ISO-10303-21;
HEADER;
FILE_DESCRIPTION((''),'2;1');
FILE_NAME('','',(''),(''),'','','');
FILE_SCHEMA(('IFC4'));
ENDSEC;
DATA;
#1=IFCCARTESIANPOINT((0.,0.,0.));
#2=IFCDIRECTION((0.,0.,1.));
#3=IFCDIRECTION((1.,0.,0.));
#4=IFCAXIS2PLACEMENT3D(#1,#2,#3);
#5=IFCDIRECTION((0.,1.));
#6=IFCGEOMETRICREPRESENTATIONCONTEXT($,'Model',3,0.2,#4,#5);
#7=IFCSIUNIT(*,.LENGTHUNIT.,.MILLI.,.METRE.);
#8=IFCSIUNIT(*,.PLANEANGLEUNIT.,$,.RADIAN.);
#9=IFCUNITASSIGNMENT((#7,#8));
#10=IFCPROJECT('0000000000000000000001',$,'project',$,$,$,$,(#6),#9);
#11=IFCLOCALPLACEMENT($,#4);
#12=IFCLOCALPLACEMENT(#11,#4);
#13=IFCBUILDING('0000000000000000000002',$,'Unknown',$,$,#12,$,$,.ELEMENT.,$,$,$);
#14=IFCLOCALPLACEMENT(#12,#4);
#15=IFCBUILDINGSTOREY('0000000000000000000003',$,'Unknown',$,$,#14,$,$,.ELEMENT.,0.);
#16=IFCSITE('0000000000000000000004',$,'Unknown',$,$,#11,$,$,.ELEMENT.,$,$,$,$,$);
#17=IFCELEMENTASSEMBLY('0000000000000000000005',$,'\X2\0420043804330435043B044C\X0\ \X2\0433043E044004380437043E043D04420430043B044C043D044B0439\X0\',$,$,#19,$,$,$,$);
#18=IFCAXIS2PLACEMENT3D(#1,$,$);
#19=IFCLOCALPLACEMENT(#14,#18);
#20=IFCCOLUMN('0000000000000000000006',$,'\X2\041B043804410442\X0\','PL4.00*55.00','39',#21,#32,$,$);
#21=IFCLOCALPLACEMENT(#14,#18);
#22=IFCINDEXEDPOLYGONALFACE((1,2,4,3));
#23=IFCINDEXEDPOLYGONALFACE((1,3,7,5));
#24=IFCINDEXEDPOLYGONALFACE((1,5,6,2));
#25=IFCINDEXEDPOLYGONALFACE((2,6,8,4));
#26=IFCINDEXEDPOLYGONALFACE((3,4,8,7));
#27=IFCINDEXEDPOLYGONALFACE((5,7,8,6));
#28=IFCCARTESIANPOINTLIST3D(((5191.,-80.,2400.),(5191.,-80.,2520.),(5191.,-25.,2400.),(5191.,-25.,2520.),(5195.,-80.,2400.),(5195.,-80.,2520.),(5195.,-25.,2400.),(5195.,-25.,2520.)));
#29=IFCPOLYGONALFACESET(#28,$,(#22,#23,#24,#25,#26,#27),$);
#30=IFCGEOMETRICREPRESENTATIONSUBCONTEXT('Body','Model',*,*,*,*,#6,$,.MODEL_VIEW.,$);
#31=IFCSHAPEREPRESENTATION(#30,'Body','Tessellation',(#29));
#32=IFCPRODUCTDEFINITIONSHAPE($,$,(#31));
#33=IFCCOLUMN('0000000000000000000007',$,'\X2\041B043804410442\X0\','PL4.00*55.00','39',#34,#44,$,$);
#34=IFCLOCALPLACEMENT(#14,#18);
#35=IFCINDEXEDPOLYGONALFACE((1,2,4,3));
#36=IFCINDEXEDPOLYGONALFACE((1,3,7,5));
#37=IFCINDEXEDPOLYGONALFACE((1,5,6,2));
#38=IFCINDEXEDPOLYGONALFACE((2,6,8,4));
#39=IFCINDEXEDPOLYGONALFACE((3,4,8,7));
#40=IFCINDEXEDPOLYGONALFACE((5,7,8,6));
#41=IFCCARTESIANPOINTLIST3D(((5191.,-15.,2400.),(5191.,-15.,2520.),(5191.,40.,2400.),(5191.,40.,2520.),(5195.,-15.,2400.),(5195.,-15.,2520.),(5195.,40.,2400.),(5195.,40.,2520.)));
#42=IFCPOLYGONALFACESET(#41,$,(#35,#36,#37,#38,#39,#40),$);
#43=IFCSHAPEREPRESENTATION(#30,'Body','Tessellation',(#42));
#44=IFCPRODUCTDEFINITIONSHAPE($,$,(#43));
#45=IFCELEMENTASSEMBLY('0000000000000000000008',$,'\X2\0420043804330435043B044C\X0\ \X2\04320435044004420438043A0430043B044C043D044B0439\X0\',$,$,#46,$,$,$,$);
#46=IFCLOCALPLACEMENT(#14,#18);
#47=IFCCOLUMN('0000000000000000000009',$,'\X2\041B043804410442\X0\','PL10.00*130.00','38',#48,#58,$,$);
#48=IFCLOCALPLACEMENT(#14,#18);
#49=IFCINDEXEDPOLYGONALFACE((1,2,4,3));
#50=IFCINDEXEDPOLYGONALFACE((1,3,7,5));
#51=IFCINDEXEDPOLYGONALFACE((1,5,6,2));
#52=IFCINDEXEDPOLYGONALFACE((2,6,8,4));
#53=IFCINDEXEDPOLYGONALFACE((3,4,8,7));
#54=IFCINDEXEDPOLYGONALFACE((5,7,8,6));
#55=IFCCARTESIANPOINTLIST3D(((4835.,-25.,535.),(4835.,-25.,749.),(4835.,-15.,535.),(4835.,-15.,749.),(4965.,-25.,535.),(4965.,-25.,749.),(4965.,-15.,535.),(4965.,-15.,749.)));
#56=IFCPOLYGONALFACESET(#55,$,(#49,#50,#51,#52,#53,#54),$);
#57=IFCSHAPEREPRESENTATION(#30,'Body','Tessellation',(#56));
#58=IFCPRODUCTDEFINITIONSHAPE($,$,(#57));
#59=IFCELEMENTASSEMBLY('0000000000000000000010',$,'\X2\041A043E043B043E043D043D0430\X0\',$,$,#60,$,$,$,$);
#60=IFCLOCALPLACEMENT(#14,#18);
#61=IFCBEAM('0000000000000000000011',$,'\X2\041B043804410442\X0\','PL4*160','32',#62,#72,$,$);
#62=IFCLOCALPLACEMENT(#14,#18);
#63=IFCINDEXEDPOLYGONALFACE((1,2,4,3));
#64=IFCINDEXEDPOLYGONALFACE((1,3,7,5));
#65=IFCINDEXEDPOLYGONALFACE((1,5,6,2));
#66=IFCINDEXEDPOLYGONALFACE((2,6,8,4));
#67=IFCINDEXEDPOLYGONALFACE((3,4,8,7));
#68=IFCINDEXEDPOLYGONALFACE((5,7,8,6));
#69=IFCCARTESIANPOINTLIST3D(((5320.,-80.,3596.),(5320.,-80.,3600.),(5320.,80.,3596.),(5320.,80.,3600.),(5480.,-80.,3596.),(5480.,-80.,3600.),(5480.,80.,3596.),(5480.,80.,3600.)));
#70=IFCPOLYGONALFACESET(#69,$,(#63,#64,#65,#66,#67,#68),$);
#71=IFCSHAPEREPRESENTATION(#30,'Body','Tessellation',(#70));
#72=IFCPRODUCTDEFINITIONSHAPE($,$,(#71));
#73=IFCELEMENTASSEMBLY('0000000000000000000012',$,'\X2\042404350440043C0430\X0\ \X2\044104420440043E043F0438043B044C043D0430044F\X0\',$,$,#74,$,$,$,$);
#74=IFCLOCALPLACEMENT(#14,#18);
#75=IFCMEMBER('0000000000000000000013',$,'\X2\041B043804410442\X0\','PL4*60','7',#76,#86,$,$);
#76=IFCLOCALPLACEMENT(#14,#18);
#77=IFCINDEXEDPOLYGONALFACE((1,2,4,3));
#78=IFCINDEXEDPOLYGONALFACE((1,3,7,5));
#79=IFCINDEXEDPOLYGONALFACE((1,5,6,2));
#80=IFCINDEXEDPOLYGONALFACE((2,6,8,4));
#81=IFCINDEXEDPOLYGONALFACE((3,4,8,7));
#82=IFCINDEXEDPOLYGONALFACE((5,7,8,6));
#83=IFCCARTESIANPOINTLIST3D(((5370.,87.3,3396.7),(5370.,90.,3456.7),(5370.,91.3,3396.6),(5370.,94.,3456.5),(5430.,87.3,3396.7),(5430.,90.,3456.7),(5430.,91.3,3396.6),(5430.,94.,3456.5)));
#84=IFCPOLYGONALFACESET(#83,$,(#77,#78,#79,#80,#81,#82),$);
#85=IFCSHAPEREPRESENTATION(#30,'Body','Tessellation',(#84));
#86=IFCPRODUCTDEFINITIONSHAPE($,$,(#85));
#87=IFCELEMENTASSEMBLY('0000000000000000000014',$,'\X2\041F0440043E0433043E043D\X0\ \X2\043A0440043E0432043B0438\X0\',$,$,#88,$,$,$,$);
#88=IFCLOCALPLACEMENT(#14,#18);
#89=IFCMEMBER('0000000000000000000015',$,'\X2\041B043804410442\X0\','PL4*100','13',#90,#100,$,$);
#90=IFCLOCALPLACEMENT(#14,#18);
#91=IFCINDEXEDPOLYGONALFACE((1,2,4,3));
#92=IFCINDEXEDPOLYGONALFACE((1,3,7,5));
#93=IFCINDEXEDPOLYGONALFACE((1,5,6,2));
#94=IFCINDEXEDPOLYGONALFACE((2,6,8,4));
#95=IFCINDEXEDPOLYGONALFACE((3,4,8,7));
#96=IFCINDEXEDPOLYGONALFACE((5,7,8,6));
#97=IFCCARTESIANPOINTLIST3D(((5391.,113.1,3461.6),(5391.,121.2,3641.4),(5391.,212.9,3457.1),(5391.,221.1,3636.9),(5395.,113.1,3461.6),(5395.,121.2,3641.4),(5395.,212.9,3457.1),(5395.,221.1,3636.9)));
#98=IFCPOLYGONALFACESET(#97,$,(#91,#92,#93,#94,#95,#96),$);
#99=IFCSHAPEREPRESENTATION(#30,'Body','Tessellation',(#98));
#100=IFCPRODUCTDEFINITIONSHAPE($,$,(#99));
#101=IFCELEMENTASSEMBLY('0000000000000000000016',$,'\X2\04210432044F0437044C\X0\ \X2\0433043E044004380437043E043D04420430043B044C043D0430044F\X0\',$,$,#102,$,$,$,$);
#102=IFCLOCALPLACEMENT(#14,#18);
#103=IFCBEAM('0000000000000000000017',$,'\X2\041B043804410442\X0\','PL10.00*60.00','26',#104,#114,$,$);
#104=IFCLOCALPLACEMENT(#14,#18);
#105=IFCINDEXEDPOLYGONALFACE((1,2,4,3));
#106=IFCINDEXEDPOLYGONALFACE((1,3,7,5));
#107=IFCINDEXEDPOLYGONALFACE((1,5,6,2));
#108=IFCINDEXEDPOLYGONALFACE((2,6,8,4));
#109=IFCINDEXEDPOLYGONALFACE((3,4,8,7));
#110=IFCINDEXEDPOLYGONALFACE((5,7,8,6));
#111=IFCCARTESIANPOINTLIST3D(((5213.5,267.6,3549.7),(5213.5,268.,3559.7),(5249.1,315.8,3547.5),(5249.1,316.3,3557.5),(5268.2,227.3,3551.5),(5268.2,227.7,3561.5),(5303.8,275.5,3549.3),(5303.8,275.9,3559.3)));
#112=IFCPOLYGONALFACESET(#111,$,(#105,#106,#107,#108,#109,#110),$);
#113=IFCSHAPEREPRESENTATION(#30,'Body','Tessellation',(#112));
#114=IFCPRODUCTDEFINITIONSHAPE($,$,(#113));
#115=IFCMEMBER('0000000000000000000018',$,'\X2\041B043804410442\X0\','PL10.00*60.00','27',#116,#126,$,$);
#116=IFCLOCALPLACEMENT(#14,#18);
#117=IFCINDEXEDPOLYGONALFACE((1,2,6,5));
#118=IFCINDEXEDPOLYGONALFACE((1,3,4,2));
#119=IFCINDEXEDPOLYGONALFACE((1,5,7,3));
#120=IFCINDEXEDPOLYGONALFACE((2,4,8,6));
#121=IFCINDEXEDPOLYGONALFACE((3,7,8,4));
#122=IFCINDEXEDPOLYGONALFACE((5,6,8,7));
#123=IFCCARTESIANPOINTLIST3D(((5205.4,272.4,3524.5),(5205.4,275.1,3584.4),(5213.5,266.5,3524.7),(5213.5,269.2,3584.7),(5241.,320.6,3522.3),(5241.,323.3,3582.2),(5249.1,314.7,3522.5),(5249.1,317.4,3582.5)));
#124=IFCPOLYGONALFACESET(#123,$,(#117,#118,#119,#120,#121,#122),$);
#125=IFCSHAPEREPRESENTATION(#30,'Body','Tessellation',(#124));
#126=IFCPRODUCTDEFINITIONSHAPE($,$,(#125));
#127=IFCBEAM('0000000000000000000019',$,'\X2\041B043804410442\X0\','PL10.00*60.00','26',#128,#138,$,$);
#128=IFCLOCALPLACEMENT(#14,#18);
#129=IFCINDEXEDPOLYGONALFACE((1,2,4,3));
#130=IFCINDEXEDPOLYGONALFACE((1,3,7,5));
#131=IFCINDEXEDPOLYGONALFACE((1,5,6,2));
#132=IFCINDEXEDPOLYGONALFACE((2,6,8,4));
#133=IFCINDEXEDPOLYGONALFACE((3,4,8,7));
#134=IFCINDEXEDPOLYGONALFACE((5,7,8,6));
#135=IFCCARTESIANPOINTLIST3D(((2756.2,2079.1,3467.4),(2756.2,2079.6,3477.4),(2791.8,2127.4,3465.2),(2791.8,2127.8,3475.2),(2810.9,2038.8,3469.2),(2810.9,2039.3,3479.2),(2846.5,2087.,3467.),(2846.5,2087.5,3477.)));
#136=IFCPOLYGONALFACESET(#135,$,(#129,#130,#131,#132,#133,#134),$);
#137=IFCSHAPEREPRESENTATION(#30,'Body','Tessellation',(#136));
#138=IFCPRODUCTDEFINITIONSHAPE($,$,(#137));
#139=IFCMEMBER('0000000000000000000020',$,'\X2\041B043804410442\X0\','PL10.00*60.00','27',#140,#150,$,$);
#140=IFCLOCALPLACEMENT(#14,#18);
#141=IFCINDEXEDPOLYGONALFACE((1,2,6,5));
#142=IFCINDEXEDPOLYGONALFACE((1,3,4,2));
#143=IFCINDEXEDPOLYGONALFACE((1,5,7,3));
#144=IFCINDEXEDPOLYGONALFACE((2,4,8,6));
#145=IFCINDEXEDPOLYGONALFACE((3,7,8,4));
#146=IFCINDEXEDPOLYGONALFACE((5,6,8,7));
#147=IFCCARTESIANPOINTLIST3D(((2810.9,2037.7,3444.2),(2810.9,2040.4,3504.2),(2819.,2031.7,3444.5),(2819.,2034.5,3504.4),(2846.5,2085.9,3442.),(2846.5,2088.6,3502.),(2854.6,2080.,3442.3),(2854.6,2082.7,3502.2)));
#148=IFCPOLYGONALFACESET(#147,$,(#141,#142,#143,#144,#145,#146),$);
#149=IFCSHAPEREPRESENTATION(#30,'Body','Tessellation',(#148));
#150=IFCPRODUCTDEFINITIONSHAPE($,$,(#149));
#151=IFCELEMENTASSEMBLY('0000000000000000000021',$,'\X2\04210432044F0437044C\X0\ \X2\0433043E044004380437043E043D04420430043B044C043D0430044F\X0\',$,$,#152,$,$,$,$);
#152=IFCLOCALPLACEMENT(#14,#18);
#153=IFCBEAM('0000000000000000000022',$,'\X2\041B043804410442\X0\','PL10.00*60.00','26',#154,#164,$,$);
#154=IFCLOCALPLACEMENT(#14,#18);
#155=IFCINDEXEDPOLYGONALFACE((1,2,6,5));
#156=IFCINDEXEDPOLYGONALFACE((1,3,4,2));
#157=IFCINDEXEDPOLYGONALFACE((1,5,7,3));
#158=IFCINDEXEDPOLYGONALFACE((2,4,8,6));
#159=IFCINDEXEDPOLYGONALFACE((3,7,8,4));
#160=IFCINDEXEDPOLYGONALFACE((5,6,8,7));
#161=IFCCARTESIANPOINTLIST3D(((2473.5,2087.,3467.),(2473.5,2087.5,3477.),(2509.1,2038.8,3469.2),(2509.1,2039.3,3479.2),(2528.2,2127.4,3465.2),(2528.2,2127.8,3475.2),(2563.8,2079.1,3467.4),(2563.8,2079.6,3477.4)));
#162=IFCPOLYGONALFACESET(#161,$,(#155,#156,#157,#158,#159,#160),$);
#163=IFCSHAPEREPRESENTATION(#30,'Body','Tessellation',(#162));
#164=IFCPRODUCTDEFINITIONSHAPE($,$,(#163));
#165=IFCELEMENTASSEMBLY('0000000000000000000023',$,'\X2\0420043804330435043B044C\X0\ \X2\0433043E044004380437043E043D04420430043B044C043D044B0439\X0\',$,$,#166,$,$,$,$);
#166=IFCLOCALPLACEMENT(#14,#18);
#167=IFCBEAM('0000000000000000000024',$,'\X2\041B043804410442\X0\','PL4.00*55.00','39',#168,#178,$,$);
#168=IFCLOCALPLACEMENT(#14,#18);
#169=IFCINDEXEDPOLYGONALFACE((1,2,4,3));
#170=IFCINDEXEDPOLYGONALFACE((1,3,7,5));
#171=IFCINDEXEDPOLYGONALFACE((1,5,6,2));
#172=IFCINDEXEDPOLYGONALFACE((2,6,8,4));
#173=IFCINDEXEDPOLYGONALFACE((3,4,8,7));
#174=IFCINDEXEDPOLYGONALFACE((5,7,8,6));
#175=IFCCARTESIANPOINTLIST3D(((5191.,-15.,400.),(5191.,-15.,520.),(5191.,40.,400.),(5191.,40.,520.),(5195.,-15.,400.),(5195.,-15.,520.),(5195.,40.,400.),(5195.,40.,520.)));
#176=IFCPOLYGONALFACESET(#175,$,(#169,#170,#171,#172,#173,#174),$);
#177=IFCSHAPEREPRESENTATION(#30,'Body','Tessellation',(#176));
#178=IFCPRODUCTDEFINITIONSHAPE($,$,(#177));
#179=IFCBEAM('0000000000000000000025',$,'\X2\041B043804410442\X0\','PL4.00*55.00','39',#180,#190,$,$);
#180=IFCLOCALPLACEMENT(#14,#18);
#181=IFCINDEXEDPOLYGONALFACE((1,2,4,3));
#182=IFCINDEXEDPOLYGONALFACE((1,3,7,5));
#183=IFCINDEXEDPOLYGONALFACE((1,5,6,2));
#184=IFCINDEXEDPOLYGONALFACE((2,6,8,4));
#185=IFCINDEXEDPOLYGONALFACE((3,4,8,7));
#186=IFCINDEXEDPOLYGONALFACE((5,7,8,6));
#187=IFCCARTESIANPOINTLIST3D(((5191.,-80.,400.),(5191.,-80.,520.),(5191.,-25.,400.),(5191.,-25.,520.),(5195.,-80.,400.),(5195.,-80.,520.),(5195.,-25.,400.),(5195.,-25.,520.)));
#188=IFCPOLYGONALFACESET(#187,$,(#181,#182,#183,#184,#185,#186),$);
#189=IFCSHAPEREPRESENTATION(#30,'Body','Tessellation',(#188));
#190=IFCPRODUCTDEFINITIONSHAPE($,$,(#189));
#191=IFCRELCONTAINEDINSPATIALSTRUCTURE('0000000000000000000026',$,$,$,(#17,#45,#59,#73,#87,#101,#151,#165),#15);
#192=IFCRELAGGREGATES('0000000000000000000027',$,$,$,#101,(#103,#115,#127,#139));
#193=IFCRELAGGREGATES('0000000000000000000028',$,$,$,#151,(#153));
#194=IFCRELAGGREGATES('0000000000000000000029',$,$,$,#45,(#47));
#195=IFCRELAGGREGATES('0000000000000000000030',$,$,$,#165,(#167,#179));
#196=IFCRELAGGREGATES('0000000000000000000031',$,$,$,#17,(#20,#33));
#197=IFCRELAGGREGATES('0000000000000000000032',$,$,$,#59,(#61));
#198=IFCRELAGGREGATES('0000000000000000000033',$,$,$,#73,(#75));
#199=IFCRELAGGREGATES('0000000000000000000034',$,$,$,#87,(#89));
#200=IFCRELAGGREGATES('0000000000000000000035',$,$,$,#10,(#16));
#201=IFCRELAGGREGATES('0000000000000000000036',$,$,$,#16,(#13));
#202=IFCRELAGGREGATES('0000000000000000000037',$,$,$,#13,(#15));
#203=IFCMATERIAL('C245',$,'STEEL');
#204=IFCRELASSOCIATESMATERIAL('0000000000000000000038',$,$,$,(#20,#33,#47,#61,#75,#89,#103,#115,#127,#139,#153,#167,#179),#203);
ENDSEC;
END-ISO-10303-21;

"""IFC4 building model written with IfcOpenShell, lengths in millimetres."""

from ifc_helpers import new_model, si_unit, direction, frame, origin_with_axes, place, context, subcontext, project, spatial, line, indexed_curve, outline, extrude, material, element, aggregate, save


model = new_model("IFC4")

# Units and contexts
model_context = context("Model", 3, precision=0.2, world=origin_with_axes(), true_north=direction((0.0, 1.0)))
body_context = subcontext(model_context, "Body", "Model", "MODEL_VIEW")
ifc_project = project(units=[si_unit("LENGTHUNIT", "METRE", prefix="MILLI"), si_unit("PLANEANGLEUNIT", "RADIAN")], contexts=[model_context])

# Site, building, storey
site_placement = place(None, origin_with_axes())
site = spatial("IfcSite", under=ifc_project, at=site_placement, Name="Unknown", CompositionType="ELEMENT")
building_placement = place(site_placement, origin_with_axes())
building = spatial("IfcBuilding", under=site, at=building_placement, Name="Unknown", CompositionType="ELEMENT")
storey_placement = place(building_placement, origin_with_axes())
storey = spatial("IfcBuildingStorey", under=building, at=storey_placement, Name="Unknown", CompositionType="ELEMENT", Elevation=0.0)

# Element assembly, columns
assembly_1_placement = place(storey_placement, frame((0.0, -20.0, 2460.0), z_axis=(0.0, -1.0, 0.0), x_axis=(1.0, 0.0, 0.0)))
assembly_1 = element("IfcElementAssembly", 1, at=assembly_1_placement, inside=storey, Name="Ригель горизонтальный")
ifc_material_1 = material(Name="C245", Category="STEEL")
column_1_placement = place(assembly_1_placement, frame((5193.0, -60.0, 32.5), z_axis=(-1.0, 0.0, 0.0), x_axis=(0.0, 1.0, 0.0)))
column_1 = element("IfcColumn", 2, at=column_1_placement, material=ifc_material_1, Name="Лист", Description="PL4.00*55.00", ObjectType="39", context=body_context, shape_type="SolidModel", body=[
    extrude(outline(indexed_curve([(-2.0, -27.5), (2.0, -27.5), (2.0, 27.5), (-2.0, 27.5)], segments=[line(1, 2, 3, 4, 1)])), frame((0.0, 0.0, 0.0), z_axis=(-1.0, 0.0, 0.0), x_axis=(0.0, 0.0, 1.0)), (0.0, 0.0, -1.0), 120.0),
])
column_2_placement = place(assembly_1_placement, frame((5193.0, -60.0, -32.5), z_axis=(1.0, 0.0, 0.0), x_axis=(0.0, 1.0, 0.0)))
column_2 = element("IfcColumn", 3, at=column_2_placement, material=ifc_material_1, Name="Лист", Description="PL4.00*55.00", ObjectType="39", context=body_context, shape_type="SolidModel", body=[
    extrude(outline(indexed_curve([(-2.0, -27.5), (2.0, -27.5), (2.0, 27.5), (-2.0, 27.5)], segments=[line(1, 2, 3, 4, 1)])), frame((0.0, 0.0, 0.0), z_axis=(-1.0, 0.0, 0.0), x_axis=(0.0, 0.0, 1.0)), (0.0, 0.0, -1.0), 120.0),
])

# Element assembly, column
assembly_2_placement = place(storey_placement, frame((4900.0, -20.0, 2400.0), z_axis=(0.0, -1.0, 0.0), x_axis=(0.0, 0.0, -1.0)))
assembly_2 = element("IfcElementAssembly", 4, at=assembly_2_placement, inside=storey, Name="Ригель вертикальный")
column_3_placement = place(assembly_2_placement, frame((1865.0, 0.0, 0.0), z_axis=(0.0, 0.0, 1.0), x_axis=(-1.0, 0.0, 0.0)))
column_3 = element("IfcColumn", 5, at=column_3_placement, material=ifc_material_1, Name="Лист", Description="PL10.00*130.00", ObjectType="38", context=body_context, shape_type="SolidModel", body=[
    extrude(outline(indexed_curve([(-5.0, -65.0), (5.0, -65.0), (5.0, 65.0), (-5.0, 65.0)], segments=[line(1, 2, 3, 4, 1)])), frame((0.0, 0.0, 0.0), z_axis=(-1.0, 0.0, 0.0), x_axis=(0.0, 0.0, 1.0)), (0.0, 0.0, -1.0), 214.0),
])

# Element assembly, beam
assembly_3_placement = place(storey_placement, frame((5400.0, 0.0, -40.0), z_axis=(-1.0, 0.0, 0.0), x_axis=(0.0, 0.0, 1.0)))
assembly_3 = element("IfcElementAssembly", 6, at=assembly_3_placement, inside=storey, Name="Колонна")
beam_1_placement = place(assembly_3_placement, frame((3638.0, -80.0, 0.0), z_axis=(-1.0, 0.0, 0.0), x_axis=(0.0, 1.0, 0.0)))
beam_1 = element("IfcBeam", 7, at=beam_1_placement, material=ifc_material_1, Name="Лист", Description="PL4*160", ObjectType="32", context=body_context, shape_type="SolidModel", body=[
    extrude(outline(indexed_curve([(-2.0, -80.0), (2.0, -80.0), (2.0, 80.0), (-2.0, 80.0)], segments=[line(1, 2, 3, 4, 1)])), frame((0.0, 0.0, 0.0), z_axis=(-1.0, 0.0, 0.0), x_axis=(0.0, 0.0, 1.0)), (0.0, 0.0, -1.0), 160.0),
])

# Element assembly, member
assembly_4_placement = place(storey_placement, frame((5400.0, 88.6, 3426.7), z_axis=(1.0, 0.0, 0.0), x_axis=(0.0, 0.998969, -0.045408)))
assembly_4 = element("IfcElementAssembly", 8, at=assembly_4_placement, inside=storey, Name="Ферма стропильная")
member_1_placement = place(assembly_4_placement, frame((2.0, -30.0, 0.0), z_axis=(1.0, 0.0, 0.0), x_axis=(0.0, 1.0, 0.0)))
member_1 = element("IfcMember", 9, at=member_1_placement, material=ifc_material_1, Name="Лист", Description="PL4*60", ObjectType="7", context=body_context, shape_type="SolidModel", body=[
    extrude(outline(indexed_curve([(-2.0, -30.0), (2.0, -30.0), (2.0, 30.0), (-2.0, 30.0)], segments=[line(1, 2, 3, 4, 1)])), frame((0.0, 0.0, 0.0), z_axis=(-1.0, 0.0, 0.0), x_axis=(0.0, 0.0, 1.0)), (0.0, 0.0, -1.0), 60.0),
])

# Element assembly, member
assembly_5_placement = place(storey_placement, frame((-595.0, 167.1, 3549.3), z_axis=(0.0, -0.998969, 0.045408), x_axis=(1.0, 0.0, 0.0)))
assembly_5 = element("IfcElementAssembly", 10, at=assembly_5_placement, inside=storey, Name="Прогон кровли")
member_2_placement = place(assembly_5_placement, frame((5988.0, -90.0, 0.0), z_axis=(-1.0, 0.0, 0.0), x_axis=(0.0, 1.0, 0.0)))
member_2 = element("IfcMember", 11, at=member_2_placement, material=ifc_material_1, Name="Лист", Description="PL4*100", ObjectType="13", context=body_context, shape_type="SolidModel", body=[
    extrude(outline(indexed_curve([(-2.0, -50.0), (2.0, -50.0), (2.0, 50.0), (-2.0, 50.0)], segments=[line(1, 2, 3, 4, 1)])), frame((0.0, 0.0, 0.0), z_axis=(-1.0, 0.0, 0.0), x_axis=(0.0, 0.0, 1.0)), (0.0, 0.0, -1.0), 180.0),
])

# Element assembly, beams, members
assembly_6_placement = place(storey_placement, frame((5400.0, 167.5, 3559.3), z_axis=(0.593795, 0.803786, -0.036536), x_axis=(-0.804616, 0.593183, -0.026963)))
assembly_6 = element("IfcElementAssembly", 12, at=assembly_6_placement, inside=storey, Name="Связь горизонтальная")
beam_2_placement = place(assembly_6_placement, frame((141.7, 0.0, 0.0), z_axis=(0.0, 1.0, 0.0), x_axis=(1.0, 0.0, 0.0)))
beam_2 = element("IfcBeam", 13, at=beam_2_placement, material=ifc_material_1, Name="Лист", Description="PL10.00*60.00", ObjectType="26", context=body_context, shape_type="SolidModel", body=[
    extrude(outline(indexed_curve([(-5.0, -30.0), (5.0, -30.0), (5.0, 30.0), (-5.0, 30.0)], segments=[line(1, 2, 3, 4, 1)])), frame((0.0, 0.0, 0.0), z_axis=(-1.0, 0.0, 0.0), x_axis=(0.0, 0.0, 1.0)), (0.0, 0.0, -1.0), 68.0),
])
member_3_placement = place(assembly_6_placement, frame((214.7, 30.0, 0.0), z_axis=(-1.0, 0.0, 0.0), x_axis=(0.0, -1.0, 0.0)))
member_3 = element("IfcMember", 14, at=member_3_placement, material=ifc_material_1, Name="Лист", Description="PL10.00*60.00", ObjectType="27", context=body_context, shape_type="SolidModel", body=[
    extrude(outline(indexed_curve([(-5.0, -30.0), (5.0, -30.0), (5.0, 30.0), (-5.0, 30.0)], segments=[line(1, 2, 3, 4, 1)])), frame((0.0, 0.0, 0.0), z_axis=(-1.0, 0.0, 0.0), x_axis=(0.0, 0.0, 1.0)), (0.0, 0.0, -1.0), 60.0),
])
beam_3_placement = place(assembly_6_placement, frame((3263.7, 0.0, 0.0), z_axis=(0.0, -1.0, 0.0), x_axis=(-1.0, 0.0, 0.0)))
beam_3 = element("IfcBeam", 15, at=beam_3_placement, material=ifc_material_1, Name="Лист", Description="PL10.00*60.00", ObjectType="26", context=body_context, shape_type="SolidModel", body=[
    extrude(outline(indexed_curve([(-5.0, -30.0), (5.0, -30.0), (5.0, 30.0), (-5.0, 30.0)], segments=[line(1, 2, 3, 4, 1)])), frame((0.0, 0.0, 0.0), z_axis=(-1.0, 0.0, 0.0), x_axis=(0.0, 0.0, 1.0)), (0.0, 0.0, -1.0), 68.0),
])
member_4_placement = place(assembly_6_placement, frame((3190.7, -30.0, 0.0), z_axis=(1.0, 0.0, 0.0), x_axis=(0.0, 1.0, 0.0)))
member_4 = element("IfcMember", 16, at=member_4_placement, material=ifc_material_1, Name="Лист", Description="PL10.00*60.00", ObjectType="27", context=body_context, shape_type="SolidModel", body=[
    extrude(outline(indexed_curve([(-5.0, -30.0), (5.0, -30.0), (5.0, 30.0), (-5.0, 30.0)], segments=[line(1, 2, 3, 4, 1)])), frame((0.0, 0.0, 0.0), z_axis=(-1.0, 0.0, 0.0), x_axis=(0.0, 0.0, 1.0)), (0.0, 0.0, -1.0), 60.0),
])
aggregate(assembly_6, [beam_2, member_3, beam_3, member_4])

# Element assembly, beam
assembly_7_placement = place(storey_placement, frame((-80.0, 167.5, 3559.3), z_axis=(0.593795, -0.803786, 0.036536), x_axis=(0.804616, 0.593183, -0.026963)))
assembly_7 = element("IfcElementAssembly", 17, at=assembly_7_placement, inside=storey, Name="Связь горизонтальная")
beam_4_placement = place(assembly_7_placement, frame((3263.7, 0.0, 0.0), z_axis=(0.0, -1.0, 0.0), x_axis=(-1.0, 0.0, 0.0)))
beam_4 = element("IfcBeam", 18, at=beam_4_placement, material=ifc_material_1, Name="Лист", Description="PL10.00*60.00", ObjectType="26", context=body_context, shape_type="SolidModel", body=[
    extrude(outline(indexed_curve([(-5.0, -30.0), (5.0, -30.0), (5.0, 30.0), (-5.0, 30.0)], segments=[line(1, 2, 3, 4, 1)])), frame((0.0, 0.0, 0.0), z_axis=(-1.0, 0.0, 0.0), x_axis=(0.0, 0.0, 1.0)), (0.0, 0.0, -1.0), 68.0),
])
aggregate(assembly_7, [beam_4])

# Element assembly, beams
assembly_8_placement = place(storey_placement, frame((0.0, -20.0, 460.0), z_axis=(0.0, -1.0, 0.0), x_axis=(1.0, 0.0, 0.0)))
assembly_8 = element("IfcElementAssembly", 19, at=assembly_8_placement, inside=storey, Name="Ригель горизонтальный")
beam_5_placement = place(assembly_8_placement, frame((5193.0, 60.0, -32.5), z_axis=(-1.0, 0.0, 0.0), x_axis=(0.0, -1.0, 0.0)))
beam_5 = element("IfcBeam", 20, at=beam_5_placement, material=ifc_material_1, Name="Лист", Description="PL4.00*55.00", ObjectType="39", context=body_context, shape_type="SolidModel", body=[
    extrude(outline(indexed_curve([(-2.0, -27.5), (2.0, -27.5), (2.0, 27.5), (-2.0, 27.5)], segments=[line(1, 2, 3, 4, 1)])), frame((0.0, 0.0, 0.0), z_axis=(-1.0, 0.0, 0.0), x_axis=(0.0, 0.0, 1.0)), (0.0, 0.0, -1.0), 120.0),
])
beam_6_placement = place(assembly_8_placement, frame((5193.0, 60.0, 32.5), z_axis=(1.0, 0.0, 0.0), x_axis=(0.0, -1.0, 0.0)))
beam_6 = element("IfcBeam", 21, at=beam_6_placement, material=ifc_material_1, Name="Лист", Description="PL4.00*55.00", ObjectType="39", context=body_context, shape_type="SolidModel", body=[
    extrude(outline(indexed_curve([(-2.0, -27.5), (2.0, -27.5), (2.0, 27.5), (-2.0, 27.5)], segments=[line(1, 2, 3, 4, 1)])), frame((0.0, 0.0, 0.0), z_axis=(-1.0, 0.0, 0.0), x_axis=(0.0, 0.0, 1.0)), (0.0, 0.0, -1.0), 120.0),
])

aggregate(assembly_2, [column_3])

aggregate(assembly_8, [beam_5, beam_6])
aggregate(assembly_1, [column_1, column_2])
aggregate(assembly_3, [beam_1])
aggregate(assembly_4, [member_1])
aggregate(assembly_5, [member_2])

save(model, "model.ifc")
